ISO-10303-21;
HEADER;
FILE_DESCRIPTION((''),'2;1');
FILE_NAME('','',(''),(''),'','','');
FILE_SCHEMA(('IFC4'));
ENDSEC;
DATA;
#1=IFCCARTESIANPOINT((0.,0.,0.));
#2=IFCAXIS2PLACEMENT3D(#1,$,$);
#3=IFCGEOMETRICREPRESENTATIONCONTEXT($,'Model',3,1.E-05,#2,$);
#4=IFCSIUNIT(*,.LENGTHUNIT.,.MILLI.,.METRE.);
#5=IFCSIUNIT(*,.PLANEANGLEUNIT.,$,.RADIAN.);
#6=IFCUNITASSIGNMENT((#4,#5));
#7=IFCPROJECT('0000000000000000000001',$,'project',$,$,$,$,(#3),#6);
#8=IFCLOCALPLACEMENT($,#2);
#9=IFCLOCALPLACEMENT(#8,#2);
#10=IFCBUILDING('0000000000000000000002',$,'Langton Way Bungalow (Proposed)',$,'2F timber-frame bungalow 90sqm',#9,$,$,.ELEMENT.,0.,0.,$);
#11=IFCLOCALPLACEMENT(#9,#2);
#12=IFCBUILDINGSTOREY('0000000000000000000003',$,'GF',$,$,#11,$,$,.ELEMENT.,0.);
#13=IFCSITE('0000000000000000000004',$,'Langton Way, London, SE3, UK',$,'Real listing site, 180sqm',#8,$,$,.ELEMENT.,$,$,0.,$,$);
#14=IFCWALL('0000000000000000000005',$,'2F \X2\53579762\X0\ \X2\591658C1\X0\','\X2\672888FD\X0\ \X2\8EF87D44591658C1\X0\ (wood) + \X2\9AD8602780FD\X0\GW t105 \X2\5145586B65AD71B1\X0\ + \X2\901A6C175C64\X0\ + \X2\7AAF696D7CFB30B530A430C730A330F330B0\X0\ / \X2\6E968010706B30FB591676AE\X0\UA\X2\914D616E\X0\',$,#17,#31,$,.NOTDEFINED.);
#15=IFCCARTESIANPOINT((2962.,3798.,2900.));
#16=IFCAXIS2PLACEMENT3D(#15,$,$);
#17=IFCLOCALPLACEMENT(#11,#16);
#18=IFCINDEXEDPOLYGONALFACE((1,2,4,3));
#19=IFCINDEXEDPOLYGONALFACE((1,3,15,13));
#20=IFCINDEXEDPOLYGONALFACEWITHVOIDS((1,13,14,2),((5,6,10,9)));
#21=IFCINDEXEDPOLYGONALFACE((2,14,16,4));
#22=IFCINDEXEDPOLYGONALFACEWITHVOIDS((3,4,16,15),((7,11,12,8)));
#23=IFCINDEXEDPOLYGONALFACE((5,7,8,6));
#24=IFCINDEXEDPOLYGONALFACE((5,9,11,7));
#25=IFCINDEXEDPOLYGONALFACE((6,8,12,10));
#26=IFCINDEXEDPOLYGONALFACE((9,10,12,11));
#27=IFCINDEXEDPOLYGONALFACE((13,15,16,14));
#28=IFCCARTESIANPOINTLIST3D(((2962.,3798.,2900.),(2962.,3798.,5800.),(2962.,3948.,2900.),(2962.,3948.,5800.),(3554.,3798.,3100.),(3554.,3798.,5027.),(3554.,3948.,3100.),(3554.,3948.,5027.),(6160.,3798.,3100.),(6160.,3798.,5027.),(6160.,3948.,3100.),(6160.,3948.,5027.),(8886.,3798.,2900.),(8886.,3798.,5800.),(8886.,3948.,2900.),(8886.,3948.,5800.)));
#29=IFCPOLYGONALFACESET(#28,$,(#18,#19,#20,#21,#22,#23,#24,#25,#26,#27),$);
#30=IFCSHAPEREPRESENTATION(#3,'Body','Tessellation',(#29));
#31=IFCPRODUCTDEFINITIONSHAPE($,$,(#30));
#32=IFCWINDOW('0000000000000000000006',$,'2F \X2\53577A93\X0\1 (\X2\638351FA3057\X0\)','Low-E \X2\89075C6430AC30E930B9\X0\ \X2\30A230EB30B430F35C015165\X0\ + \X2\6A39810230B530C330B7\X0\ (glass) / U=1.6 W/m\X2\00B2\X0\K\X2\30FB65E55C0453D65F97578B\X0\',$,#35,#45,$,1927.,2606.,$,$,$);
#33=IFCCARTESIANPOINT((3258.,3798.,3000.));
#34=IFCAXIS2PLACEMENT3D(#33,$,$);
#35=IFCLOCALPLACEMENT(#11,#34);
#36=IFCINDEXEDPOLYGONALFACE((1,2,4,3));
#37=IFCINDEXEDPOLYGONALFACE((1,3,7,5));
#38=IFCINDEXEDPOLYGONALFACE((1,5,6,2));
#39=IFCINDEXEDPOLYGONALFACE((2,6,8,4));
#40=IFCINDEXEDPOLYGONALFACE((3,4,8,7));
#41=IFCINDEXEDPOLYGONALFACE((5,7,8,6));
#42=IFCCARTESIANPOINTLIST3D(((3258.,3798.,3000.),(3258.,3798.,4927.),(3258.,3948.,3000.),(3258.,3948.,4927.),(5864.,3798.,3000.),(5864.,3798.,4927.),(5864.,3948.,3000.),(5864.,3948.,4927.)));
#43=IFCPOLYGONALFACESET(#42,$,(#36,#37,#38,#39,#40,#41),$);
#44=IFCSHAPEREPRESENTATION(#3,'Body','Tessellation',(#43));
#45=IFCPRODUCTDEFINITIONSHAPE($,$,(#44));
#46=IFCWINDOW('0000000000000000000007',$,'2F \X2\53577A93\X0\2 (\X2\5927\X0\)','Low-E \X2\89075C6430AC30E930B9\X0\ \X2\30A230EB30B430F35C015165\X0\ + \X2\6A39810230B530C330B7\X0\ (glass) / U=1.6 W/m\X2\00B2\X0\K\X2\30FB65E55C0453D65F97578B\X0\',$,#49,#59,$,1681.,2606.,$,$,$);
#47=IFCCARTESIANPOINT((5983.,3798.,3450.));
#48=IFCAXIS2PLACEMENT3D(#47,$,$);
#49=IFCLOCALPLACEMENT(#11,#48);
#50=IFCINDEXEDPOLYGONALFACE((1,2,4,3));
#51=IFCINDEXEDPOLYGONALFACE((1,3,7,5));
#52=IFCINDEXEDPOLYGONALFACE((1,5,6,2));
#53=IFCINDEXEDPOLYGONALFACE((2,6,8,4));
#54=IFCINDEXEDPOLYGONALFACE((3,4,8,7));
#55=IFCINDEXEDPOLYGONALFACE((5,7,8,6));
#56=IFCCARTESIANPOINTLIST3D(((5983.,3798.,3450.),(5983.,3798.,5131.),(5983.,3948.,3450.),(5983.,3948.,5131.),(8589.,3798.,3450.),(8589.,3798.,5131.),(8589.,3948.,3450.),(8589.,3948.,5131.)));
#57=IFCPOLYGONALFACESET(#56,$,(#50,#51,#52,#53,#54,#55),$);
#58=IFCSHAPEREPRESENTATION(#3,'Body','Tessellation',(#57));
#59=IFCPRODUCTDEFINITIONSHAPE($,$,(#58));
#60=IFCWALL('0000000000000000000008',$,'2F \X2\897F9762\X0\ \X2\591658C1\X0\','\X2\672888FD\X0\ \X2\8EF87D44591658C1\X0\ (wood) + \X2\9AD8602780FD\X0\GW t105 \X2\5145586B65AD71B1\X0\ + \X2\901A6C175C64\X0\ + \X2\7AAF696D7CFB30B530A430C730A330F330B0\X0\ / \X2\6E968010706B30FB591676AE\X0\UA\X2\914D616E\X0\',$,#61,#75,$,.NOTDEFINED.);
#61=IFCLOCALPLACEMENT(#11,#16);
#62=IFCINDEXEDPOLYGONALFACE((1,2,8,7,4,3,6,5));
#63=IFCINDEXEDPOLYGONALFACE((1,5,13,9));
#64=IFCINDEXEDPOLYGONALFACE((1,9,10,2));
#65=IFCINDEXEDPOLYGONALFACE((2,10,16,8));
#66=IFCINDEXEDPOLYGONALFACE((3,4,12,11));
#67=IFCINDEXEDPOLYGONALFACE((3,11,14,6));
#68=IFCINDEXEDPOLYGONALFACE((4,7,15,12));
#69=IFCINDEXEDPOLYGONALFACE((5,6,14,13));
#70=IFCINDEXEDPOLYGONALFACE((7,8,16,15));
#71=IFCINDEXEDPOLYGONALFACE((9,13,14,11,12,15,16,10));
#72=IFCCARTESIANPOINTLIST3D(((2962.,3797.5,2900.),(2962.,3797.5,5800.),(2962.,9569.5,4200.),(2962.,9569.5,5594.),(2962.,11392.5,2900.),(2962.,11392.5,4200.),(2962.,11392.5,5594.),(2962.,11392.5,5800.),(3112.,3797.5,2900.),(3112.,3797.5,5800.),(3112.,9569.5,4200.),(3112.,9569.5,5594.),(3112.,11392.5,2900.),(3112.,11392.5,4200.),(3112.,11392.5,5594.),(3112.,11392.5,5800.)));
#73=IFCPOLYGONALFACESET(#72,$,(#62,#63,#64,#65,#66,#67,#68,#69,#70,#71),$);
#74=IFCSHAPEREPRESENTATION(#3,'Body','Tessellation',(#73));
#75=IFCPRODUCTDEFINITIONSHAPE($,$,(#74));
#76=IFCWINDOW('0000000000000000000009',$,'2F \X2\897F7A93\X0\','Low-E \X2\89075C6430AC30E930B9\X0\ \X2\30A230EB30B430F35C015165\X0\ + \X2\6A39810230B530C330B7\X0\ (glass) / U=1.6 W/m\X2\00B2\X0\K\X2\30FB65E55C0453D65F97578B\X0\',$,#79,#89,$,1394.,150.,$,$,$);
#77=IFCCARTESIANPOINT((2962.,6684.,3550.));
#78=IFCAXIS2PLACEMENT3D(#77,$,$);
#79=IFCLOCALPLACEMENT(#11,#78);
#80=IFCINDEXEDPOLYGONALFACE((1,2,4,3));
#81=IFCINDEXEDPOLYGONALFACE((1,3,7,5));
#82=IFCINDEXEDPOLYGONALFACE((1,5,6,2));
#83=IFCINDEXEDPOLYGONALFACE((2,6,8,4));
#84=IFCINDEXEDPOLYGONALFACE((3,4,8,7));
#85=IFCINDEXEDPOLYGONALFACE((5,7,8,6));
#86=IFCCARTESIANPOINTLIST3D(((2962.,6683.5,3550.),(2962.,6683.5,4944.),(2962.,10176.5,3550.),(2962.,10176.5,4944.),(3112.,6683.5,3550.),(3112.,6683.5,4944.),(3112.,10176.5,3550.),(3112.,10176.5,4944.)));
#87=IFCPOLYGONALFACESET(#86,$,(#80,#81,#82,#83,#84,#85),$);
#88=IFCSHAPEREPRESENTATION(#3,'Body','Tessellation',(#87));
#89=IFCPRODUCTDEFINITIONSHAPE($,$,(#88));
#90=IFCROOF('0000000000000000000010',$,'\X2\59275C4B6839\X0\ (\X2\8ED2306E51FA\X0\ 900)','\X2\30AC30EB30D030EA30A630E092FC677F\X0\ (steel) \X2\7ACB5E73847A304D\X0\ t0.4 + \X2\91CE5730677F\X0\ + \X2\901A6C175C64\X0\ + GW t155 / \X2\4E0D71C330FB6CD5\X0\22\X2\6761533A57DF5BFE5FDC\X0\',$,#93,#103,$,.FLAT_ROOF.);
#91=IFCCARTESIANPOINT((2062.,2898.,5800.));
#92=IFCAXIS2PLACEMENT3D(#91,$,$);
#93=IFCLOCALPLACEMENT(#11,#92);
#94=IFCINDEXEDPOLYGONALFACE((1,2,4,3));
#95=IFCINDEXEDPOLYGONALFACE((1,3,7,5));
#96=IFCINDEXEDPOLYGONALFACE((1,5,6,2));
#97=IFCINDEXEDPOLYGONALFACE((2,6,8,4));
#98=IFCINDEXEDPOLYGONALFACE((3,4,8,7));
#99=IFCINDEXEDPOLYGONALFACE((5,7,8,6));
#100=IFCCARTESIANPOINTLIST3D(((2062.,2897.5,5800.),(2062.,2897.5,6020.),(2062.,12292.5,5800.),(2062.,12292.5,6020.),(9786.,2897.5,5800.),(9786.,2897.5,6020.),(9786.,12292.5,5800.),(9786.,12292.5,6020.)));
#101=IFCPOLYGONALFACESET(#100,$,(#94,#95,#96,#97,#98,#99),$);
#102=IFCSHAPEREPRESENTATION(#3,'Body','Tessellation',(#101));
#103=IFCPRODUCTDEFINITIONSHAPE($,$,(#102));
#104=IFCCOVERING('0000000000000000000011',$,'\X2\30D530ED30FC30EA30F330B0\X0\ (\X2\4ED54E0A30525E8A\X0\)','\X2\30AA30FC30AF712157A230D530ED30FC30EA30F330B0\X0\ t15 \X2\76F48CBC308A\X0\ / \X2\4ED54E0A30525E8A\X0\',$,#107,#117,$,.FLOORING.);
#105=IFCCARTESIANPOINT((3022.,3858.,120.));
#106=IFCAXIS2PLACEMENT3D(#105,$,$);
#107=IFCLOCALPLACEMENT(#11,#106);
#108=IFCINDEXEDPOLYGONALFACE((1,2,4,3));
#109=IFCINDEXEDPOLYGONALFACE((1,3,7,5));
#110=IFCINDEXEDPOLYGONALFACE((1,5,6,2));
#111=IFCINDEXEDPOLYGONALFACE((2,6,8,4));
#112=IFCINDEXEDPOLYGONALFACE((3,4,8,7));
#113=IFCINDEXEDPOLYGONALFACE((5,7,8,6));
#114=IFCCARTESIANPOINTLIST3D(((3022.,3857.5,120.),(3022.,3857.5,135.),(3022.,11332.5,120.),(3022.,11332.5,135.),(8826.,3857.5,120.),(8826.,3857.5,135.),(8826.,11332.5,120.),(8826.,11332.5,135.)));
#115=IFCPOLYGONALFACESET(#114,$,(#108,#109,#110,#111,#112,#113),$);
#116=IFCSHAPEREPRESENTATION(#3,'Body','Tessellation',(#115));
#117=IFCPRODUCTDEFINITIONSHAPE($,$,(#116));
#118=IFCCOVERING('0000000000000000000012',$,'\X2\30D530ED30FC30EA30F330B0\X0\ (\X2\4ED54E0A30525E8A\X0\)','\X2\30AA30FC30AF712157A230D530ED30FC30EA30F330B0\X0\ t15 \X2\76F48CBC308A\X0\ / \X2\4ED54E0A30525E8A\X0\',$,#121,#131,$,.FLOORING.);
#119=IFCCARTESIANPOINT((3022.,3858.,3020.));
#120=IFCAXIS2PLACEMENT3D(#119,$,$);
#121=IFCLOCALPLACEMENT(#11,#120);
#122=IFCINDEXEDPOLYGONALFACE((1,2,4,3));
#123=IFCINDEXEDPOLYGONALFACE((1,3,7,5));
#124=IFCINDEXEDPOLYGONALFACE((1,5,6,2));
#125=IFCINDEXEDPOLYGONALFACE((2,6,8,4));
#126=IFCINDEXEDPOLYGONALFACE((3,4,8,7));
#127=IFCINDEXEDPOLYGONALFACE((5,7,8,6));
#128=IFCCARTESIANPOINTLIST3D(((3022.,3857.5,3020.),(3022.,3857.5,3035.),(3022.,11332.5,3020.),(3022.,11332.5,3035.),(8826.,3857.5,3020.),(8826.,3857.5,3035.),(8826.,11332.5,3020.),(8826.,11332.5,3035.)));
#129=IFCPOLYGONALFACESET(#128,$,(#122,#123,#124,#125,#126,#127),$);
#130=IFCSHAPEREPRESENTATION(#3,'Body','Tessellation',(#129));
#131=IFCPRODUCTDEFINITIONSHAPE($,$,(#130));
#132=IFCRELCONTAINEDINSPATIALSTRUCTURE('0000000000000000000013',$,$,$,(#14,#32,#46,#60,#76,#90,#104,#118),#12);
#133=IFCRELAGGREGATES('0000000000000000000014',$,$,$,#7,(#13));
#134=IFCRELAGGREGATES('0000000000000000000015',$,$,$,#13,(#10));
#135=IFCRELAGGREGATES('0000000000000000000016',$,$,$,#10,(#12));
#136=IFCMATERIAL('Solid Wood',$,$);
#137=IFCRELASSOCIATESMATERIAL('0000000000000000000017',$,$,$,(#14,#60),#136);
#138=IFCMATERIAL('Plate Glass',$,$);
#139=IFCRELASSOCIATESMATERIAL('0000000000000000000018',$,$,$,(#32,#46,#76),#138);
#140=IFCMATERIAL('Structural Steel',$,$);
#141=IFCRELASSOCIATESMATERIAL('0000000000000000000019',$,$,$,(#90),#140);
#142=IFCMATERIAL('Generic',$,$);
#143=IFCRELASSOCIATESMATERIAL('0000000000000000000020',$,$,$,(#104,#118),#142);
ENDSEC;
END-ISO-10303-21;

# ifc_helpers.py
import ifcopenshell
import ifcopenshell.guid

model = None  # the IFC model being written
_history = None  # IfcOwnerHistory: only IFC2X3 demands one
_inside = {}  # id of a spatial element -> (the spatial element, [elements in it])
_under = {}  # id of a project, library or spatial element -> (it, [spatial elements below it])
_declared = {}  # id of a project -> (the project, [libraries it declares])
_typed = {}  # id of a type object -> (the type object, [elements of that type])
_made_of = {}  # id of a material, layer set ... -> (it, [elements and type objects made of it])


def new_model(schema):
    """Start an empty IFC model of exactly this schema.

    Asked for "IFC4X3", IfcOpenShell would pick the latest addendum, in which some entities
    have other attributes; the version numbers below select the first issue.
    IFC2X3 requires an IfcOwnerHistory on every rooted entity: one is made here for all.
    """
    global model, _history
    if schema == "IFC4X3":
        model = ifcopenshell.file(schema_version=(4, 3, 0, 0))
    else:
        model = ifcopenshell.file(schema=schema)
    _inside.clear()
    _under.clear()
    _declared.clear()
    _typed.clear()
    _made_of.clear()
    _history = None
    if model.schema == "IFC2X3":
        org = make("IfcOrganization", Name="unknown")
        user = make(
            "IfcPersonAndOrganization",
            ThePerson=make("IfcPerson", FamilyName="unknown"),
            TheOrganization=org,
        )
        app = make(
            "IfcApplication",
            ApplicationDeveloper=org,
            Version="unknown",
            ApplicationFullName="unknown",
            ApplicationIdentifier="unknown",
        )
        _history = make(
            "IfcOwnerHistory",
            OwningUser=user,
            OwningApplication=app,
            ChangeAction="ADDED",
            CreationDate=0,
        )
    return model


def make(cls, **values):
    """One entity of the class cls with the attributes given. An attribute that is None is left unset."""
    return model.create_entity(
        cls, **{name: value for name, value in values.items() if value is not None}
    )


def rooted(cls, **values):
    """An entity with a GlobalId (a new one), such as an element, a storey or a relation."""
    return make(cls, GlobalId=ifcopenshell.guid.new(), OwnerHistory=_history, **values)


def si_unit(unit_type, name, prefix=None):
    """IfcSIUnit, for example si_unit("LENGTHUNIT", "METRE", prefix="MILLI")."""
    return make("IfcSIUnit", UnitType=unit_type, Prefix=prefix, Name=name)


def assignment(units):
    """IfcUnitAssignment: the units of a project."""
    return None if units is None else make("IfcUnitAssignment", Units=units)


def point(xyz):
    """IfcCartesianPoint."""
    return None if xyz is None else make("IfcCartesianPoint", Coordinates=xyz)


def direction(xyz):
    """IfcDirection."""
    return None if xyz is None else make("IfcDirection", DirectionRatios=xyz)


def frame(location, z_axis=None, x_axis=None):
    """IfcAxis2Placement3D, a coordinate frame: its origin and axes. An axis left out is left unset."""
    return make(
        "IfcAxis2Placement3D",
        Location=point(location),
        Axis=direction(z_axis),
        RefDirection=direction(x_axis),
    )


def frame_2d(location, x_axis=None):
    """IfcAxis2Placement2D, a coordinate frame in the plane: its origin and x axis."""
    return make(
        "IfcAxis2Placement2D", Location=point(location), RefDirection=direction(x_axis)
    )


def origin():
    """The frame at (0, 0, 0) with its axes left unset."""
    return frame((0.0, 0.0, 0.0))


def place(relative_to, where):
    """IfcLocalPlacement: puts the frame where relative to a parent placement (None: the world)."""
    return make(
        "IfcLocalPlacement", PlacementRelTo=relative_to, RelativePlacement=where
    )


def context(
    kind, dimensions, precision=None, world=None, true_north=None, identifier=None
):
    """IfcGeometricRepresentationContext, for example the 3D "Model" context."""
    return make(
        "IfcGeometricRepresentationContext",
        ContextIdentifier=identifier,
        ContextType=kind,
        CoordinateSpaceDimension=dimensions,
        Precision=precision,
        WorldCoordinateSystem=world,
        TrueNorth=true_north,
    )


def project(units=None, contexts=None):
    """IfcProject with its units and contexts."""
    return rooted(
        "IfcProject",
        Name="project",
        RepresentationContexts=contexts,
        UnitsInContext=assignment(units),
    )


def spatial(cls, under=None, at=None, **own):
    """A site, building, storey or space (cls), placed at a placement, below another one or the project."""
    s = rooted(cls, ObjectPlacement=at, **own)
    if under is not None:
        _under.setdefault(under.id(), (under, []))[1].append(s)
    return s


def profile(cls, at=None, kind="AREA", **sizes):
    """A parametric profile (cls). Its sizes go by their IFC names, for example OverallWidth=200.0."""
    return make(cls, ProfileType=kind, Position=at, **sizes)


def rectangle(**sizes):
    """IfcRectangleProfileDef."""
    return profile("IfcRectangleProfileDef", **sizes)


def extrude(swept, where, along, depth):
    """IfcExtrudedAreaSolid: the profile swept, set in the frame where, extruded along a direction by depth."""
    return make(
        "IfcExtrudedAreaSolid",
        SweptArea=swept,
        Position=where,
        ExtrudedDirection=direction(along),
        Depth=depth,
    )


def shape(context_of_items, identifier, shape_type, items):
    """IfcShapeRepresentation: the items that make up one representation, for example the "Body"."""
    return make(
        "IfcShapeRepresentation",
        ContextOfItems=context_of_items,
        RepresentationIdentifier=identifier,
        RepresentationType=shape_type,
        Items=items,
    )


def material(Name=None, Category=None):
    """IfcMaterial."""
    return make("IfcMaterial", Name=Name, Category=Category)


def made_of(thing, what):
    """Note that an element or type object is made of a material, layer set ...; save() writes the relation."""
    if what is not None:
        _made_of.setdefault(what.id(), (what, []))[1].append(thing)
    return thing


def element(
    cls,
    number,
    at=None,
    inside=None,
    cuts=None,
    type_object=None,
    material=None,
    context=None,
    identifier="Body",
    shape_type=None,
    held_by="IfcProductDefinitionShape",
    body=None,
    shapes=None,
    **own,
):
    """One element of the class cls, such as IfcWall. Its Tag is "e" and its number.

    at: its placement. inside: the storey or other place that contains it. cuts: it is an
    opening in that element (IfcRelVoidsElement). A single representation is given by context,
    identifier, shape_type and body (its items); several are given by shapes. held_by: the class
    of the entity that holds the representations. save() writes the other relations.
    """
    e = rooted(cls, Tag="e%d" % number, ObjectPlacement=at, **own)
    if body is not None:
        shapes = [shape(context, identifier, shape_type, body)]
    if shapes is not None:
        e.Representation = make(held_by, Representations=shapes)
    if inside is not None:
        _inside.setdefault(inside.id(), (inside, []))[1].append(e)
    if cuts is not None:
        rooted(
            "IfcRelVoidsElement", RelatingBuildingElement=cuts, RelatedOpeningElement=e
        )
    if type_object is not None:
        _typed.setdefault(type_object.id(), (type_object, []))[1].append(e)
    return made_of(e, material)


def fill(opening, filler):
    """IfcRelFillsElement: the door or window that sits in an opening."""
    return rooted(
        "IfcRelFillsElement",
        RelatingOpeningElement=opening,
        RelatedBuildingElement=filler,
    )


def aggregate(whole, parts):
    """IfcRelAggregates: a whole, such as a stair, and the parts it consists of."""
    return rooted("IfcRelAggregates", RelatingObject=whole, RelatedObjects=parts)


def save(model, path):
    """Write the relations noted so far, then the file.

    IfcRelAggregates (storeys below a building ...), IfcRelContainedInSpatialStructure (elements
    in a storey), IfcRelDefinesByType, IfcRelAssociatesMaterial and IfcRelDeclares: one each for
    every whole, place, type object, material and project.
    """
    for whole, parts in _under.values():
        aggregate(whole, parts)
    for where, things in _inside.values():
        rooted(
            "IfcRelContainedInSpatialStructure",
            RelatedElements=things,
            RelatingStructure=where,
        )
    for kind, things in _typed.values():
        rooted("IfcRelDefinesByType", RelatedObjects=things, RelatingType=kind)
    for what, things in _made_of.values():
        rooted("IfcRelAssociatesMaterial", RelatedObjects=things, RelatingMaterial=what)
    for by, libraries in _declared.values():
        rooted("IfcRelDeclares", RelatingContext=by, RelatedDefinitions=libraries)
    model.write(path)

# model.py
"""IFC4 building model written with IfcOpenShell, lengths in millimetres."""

from ifc_helpers import new_model, si_unit, frame, frame_2d, origin, place, context, project, spatial, rectangle, extrude, material, element, fill, save


model = new_model("IFC4")

# Units and contexts
model_context = context("Model", 3, precision=1e-05, world=origin())
ifc_project = project(units=[si_unit("LENGTHUNIT", "METRE", prefix="MILLI"), si_unit("PLANEANGLEUNIT", "RADIAN")], contexts=[model_context])

# Site, building, storey
site_placement = place(None, origin())
site = spatial("IfcSite", under=ifc_project, at=site_placement, Name="Langton Way, London, SE3, UK", ObjectType="Real listing site, 180sqm", CompositionType="ELEMENT", RefElevation=0.0)
building_placement = place(site_placement, origin())
building = spatial("IfcBuilding", under=site, at=building_placement, Name="Langton Way Bungalow (Proposed)", ObjectType="2F timber-frame bungalow 90sqm", CompositionType="ELEMENT", ElevationOfRefHeight=0.0, ElevationOfTerrain=0.0)
storey_placement = place(building_placement, origin())
storey = spatial("IfcBuildingStorey", under=building, at=storey_placement, Name="GF", CompositionType="ELEMENT", Elevation=0.0)

# Shared definitions
ifc_material_1 = material(Name="Solid Wood")

# Shared definitions
ifc_material_2 = material(Name="Plate Glass")

# Wall, openings, windows
wall_1_placement = place(storey_placement, frame((2962.0, 3798.0, 2900.0)))
wall_1 = element("IfcWall", 1, at=wall_1_placement, inside=storey, material=ifc_material_1, Name="2F 南面 外壁", Description="木製 軸組外壁 (wood) + 高性能GW t105 充填断熱 + 通気層 + 窯業系サイディング / 準耐火・外皮UA配慮", PredefinedType="NOTDEFINED", context=model_context, shape_type="SweptSolid", body=[
    extrude(rectangle(XDim=5924.0, YDim=150.0, at=frame_2d((2962.0, 75.0))), frame((2962.0, 3798.0, 2900.0)), (0.0, 0.0, 1.0), 2900.0),
])
opening_1_placement = place(storey_placement, frame((3258.0, 3798.0, 3000.0)))
opening_1 = element("IfcOpeningElement", 2, at=opening_1_placement, cuts=wall_1, PredefinedType="NOTDEFINED", context=model_context, shape_type="SweptSolid", body=[
    extrude(rectangle(XDim=2606.0, YDim=150.0, at=frame_2d((1303.0, 75.0))), frame((3258.0, 3798.0, 3000.0)), (0.0, 0.0, 1.0), 1927.0),
])
opening_2_placement = place(storey_placement, frame((5983.0, 3798.0, 3450.0)))
opening_2 = element("IfcOpeningElement", 3, at=opening_2_placement, cuts=wall_1, PredefinedType="NOTDEFINED", context=model_context, shape_type="SweptSolid", body=[
    extrude(rectangle(XDim=2606.0, YDim=150.0, at=frame_2d((1303.0, 75.0))), frame((5983.0, 3798.0, 3450.0)), (0.0, 0.0, 1.0), 1681.0),
])
window_1_placement = place(storey_placement, frame((3258.0, 3798.0, 3000.0)))
window_1 = element("IfcWindow", 4, at=window_1_placement, inside=storey, material=ifc_material_2, Name="2F 南窓1 (掃出し)", Description="Low-E 複層ガラス アルゴン封入 + 樹脂サッシ (glass) / U=1.6 W/m²K・日射取得型", OverallHeight=1927.0, OverallWidth=2606.0, context=model_context, shape_type="SweptSolid", body=[
    extrude(rectangle(XDim=2606.0, YDim=150.0, at=frame_2d((1303.0, 75.0))), frame((3258.0, 3798.0, 3000.0)), (0.0, 0.0, 1.0), 1927.0),
])
fill(opening_1, window_1)
window_2_placement = place(storey_placement, frame((5983.0, 3798.0, 3450.0)))
window_2 = element("IfcWindow", 5, at=window_2_placement, inside=storey, material=ifc_material_2, Name="2F 南窓2 (大)", Description="Low-E 複層ガラス アルゴン封入 + 樹脂サッシ (glass) / U=1.6 W/m²K・日射取得型", OverallHeight=1681.0, OverallWidth=2606.0, context=model_context, shape_type="SweptSolid", body=[
    extrude(rectangle(XDim=2606.0, YDim=150.0, at=frame_2d((1303.0, 75.0))), frame((5983.0, 3798.0, 3450.0)), (0.0, 0.0, 1.0), 1681.0),
])
fill(opening_2, window_2)

# Wall, opening, window
wall_2_placement = place(storey_placement, frame((2962.0, 3798.0, 2900.0)))
wall_2 = element("IfcWall", 6, at=wall_2_placement, inside=storey, material=ifc_material_1, Name="2F 西面 外壁", Description="木製 軸組外壁 (wood) + 高性能GW t105 充填断熱 + 通気層 + 窯業系サイディング / 準耐火・外皮UA配慮", PredefinedType="NOTDEFINED", context=model_context, shape_type="SweptSolid", body=[
    extrude(rectangle(XDim=150.0, YDim=7595.0, at=frame_2d((75.0, 3797.0))), frame((2962.0, 3798.0, 2900.0)), (0.0, 0.0, 1.0), 2900.0),
])
opening_3_placement = place(storey_placement, frame((2962.0, 6684.0, 3550.0)))
opening_3 = element("IfcOpeningElement", 7, at=opening_3_placement, cuts=wall_2, PredefinedType="NOTDEFINED", context=model_context, shape_type="SweptSolid", body=[
    extrude(rectangle(XDim=150.0, YDim=3493.0, at=frame_2d((75.0, 1746.0))), frame((2962.0, 6684.0, 3550.0)), (0.0, 0.0, 1.0), 1394.0),
])
window_3_placement = place(storey_placement, frame((2962.0, 6684.0, 3550.0)))
window_3 = element("IfcWindow", 8, at=window_3_placement, inside=storey, material=ifc_material_2, Name="2F 西窓", Description="Low-E 複層ガラス アルゴン封入 + 樹脂サッシ (glass) / U=1.6 W/m²K・日射取得型", OverallHeight=1394.0, OverallWidth=150.0, context=model_context, shape_type="SweptSolid", body=[
    extrude(rectangle(XDim=150.0, YDim=3493.0, at=frame_2d((75.0, 1746.0))), frame((2962.0, 6684.0, 3550.0)), (0.0, 0.0, 1.0), 1394.0),
])
fill(opening_3, window_3)

# Roof
ifc_material_3 = material(Name="Structural Steel")
roof_placement = place(storey_placement, frame((2062.0, 2898.0, 5800.0)))
element("IfcRoof", 9, at=roof_placement, inside=storey, material=ifc_material_3, Name="大屋根 (軒の出 900)", Description="ガルバリウム鋼板 (steel) 立平葺き t0.4 + 野地板 + 通気層 + GW t155 / 不燃・法22条区域対応", PredefinedType="FLAT_ROOF", context=model_context, shape_type="SweptSolid", body=[
    extrude(rectangle(XDim=7724.0, YDim=9395.0, at=frame_2d((3862.0, 4697.0))), frame((2062.0, 2898.0, 5800.0)), (0.0, 0.0, 1.0), 220.0),
])

# Coverings
ifc_material_4 = material(Name="Generic")
covering_1_placement = place(storey_placement, frame((3022.0, 3858.0, 120.0)))
element("IfcCovering", 10, at=covering_1_placement, inside=storey, material=ifc_material_4, Name="フローリング (仕上げ床)", Description="オーク無垢フローリング t15 直貼り / 仕上げ床", PredefinedType="FLOORING", context=model_context, shape_type="SweptSolid", body=[
    extrude(rectangle(XDim=5804.0, YDim=7475.0, at=frame_2d((2902.0, 3737.0))), frame((3022.0, 3858.0, 120.0)), (0.0, 0.0, 1.0), 15.0),
])
covering_2_placement = place(storey_placement, frame((3022.0, 3858.0, 3020.0)))
element("IfcCovering", 11, at=covering_2_placement, inside=storey, material=ifc_material_4, Name="フローリング (仕上げ床)", Description="オーク無垢フローリング t15 直貼り / 仕上げ床", PredefinedType="FLOORING", context=model_context, shape_type="SweptSolid", body=[
    extrude(rectangle(XDim=5804.0, YDim=7475.0, at=frame_2d((2902.0, 3737.0))), frame((3022.0, 3858.0, 3020.0)), (0.0, 0.0, 1.0), 15.0),
])

save(model, "model.ifc")
